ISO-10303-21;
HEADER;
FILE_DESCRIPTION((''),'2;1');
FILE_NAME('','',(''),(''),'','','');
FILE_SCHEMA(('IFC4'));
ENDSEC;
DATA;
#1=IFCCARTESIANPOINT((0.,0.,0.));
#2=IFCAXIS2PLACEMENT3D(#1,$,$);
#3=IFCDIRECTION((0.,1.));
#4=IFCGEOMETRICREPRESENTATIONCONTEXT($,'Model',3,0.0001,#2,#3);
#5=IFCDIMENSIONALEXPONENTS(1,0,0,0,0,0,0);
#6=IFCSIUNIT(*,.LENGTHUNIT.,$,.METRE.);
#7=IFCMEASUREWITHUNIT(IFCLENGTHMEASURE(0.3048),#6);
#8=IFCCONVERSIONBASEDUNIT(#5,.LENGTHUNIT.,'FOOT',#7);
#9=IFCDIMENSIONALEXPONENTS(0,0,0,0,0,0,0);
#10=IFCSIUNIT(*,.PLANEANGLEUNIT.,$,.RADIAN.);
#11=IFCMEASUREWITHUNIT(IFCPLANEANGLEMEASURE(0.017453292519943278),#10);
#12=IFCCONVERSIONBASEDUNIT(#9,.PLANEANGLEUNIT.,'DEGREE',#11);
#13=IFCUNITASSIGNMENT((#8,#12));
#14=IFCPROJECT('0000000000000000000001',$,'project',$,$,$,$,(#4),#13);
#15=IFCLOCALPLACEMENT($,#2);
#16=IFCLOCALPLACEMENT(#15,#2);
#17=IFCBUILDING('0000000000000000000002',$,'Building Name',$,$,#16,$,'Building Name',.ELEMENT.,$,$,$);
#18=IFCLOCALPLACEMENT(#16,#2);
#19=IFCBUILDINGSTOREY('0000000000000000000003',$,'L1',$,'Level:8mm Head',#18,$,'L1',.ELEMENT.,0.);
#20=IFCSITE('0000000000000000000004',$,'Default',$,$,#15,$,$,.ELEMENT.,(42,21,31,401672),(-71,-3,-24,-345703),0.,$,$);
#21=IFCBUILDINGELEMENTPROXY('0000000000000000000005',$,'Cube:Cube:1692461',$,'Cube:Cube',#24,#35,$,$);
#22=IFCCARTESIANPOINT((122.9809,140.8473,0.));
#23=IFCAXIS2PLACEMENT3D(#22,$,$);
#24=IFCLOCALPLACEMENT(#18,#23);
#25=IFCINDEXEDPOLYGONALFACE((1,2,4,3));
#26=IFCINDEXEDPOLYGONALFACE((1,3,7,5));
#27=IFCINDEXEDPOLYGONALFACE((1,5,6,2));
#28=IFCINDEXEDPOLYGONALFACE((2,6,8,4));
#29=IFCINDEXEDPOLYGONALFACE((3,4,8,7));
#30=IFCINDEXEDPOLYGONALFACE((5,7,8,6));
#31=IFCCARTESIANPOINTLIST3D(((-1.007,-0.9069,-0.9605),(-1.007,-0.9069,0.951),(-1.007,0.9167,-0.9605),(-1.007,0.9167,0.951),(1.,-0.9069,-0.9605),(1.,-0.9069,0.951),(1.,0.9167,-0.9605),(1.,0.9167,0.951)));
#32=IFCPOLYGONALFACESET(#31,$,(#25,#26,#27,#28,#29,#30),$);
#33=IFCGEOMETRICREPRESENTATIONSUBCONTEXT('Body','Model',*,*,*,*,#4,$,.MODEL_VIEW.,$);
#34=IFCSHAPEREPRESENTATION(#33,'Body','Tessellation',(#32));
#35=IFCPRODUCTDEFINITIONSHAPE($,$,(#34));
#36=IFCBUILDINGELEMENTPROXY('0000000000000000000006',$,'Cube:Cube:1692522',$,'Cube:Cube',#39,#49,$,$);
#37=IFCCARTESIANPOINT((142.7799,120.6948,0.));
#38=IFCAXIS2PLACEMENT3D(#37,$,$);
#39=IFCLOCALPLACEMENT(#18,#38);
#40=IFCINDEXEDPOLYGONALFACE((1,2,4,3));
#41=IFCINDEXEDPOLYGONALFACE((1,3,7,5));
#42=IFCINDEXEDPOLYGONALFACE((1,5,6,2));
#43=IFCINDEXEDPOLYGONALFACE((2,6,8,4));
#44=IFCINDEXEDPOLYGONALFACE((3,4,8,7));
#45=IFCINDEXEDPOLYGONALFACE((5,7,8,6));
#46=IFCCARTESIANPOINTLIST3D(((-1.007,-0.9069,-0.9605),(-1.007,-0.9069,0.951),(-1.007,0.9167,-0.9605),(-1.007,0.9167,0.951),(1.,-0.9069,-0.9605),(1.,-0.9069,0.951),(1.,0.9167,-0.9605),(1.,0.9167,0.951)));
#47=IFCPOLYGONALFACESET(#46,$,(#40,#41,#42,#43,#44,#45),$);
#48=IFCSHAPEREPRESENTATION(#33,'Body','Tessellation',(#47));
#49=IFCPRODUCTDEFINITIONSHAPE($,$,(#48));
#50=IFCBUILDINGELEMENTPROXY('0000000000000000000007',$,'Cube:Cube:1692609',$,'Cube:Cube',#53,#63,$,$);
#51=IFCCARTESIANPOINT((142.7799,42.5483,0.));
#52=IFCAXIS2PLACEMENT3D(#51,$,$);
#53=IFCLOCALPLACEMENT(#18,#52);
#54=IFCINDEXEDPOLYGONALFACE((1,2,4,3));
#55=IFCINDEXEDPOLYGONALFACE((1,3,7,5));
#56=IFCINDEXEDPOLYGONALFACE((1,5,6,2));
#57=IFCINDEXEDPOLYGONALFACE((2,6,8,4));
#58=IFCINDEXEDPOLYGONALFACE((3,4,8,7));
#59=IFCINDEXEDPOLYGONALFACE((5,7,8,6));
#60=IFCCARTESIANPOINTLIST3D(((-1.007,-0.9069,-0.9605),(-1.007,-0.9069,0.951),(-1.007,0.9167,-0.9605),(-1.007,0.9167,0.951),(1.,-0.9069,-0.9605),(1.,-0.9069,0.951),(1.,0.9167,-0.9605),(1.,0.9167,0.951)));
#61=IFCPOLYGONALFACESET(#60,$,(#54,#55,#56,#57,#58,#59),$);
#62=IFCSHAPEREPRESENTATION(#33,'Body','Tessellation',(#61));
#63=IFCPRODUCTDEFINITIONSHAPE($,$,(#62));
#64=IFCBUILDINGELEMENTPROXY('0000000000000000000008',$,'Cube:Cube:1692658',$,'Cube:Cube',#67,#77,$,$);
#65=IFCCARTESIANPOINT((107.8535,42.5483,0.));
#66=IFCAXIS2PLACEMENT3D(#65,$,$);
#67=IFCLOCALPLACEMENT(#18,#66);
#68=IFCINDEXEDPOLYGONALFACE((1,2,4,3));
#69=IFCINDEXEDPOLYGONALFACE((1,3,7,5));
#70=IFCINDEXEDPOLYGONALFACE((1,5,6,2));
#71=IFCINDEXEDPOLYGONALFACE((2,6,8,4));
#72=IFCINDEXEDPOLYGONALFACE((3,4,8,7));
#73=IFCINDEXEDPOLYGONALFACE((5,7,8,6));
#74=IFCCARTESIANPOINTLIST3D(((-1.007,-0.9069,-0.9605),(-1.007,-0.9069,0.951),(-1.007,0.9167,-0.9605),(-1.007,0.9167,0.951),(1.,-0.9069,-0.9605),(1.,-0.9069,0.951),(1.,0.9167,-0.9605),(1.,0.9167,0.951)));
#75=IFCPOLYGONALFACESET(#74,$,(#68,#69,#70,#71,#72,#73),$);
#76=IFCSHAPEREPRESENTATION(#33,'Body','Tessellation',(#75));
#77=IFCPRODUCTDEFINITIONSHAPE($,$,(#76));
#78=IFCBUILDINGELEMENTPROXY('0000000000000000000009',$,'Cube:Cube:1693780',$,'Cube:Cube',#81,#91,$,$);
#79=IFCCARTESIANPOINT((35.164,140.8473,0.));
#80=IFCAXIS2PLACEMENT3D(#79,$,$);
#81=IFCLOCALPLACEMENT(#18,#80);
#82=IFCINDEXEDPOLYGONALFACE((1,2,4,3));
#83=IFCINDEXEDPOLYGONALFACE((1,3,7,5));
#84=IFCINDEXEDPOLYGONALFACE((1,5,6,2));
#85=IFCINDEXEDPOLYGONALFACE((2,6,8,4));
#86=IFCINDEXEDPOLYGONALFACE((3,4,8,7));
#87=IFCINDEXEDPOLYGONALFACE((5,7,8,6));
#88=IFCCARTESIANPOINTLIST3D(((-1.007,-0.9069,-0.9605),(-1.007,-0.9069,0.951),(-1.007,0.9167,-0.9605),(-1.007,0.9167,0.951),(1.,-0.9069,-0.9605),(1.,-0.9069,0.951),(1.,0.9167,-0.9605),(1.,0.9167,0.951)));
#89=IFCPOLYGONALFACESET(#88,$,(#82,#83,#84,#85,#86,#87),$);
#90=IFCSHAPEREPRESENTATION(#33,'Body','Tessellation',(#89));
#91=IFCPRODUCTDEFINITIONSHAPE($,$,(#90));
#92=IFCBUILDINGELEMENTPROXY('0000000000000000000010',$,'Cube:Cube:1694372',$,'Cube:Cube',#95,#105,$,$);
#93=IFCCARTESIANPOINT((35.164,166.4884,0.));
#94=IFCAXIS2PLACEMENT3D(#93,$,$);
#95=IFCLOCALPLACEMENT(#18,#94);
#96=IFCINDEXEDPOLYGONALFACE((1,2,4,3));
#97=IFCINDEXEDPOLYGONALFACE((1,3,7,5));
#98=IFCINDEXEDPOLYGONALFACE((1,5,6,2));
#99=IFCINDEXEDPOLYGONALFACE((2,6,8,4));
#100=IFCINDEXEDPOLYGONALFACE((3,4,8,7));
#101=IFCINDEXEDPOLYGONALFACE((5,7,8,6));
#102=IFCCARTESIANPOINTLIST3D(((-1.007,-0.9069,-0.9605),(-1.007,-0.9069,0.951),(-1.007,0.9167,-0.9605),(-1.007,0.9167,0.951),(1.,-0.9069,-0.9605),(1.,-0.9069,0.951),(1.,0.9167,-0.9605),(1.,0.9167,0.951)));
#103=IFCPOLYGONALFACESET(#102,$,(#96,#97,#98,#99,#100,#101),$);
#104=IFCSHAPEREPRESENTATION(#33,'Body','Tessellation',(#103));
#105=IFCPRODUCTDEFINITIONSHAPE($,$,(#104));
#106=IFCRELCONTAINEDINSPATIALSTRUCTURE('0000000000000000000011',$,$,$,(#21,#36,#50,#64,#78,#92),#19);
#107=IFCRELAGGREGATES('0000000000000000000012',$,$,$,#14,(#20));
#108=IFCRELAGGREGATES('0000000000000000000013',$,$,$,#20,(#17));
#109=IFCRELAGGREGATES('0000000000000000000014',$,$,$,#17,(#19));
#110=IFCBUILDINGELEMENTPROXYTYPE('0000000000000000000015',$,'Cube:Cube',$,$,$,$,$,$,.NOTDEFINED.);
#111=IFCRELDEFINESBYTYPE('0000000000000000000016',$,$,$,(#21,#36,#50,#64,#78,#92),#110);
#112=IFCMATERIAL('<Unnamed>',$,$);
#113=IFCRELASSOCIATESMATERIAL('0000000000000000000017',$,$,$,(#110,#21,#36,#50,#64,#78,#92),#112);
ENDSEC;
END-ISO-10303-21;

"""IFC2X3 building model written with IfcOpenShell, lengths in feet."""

from ifc_helpers import new_model, entity, si_unit, converted_unit, direction, frame, frame_2d, origin, place, context, subcontext, project, spatial, rectangle, extrude, source, transform, mapped, material, type_object, type_shapes, element, save


model = new_model("IFC2X3")

# Units and contexts
model_context = context("Model", 3, precision=0.0001, world=origin(), true_north=direction((0.0, 1.0)))
body_context = subcontext(model_context, "Body", "Model", "MODEL_VIEW")
ifc_project = project(units=[converted_unit("LENGTHUNIT", "FOOT", entity("IfcLengthMeasure", 0.3048), si_unit("LENGTHUNIT", "METRE"), dimensions=[1, 0, 0, 0, 0, 0, 0]), converted_unit("PLANEANGLEUNIT", "DEGREE", entity("IfcPlaneAngleMeasure", 0.017453292519943278), si_unit("PLANEANGLEUNIT", "RADIAN"), dimensions=[0, 0, 0, 0, 0, 0, 0])], contexts=[model_context])

# Site, building, storey
site_placement = place(None, origin())
site = spatial("IfcSite", under=ifc_project, at=site_placement, Name="Default", CompositionType="ELEMENT", RefLatitude=(42, 21, 31, 401672), RefLongitude=(-71, -3, -24, -345703), RefElevation=0.0)
building_placement = place(site_placement, origin())
building = spatial("IfcBuilding", under=site, at=building_placement, Name="Building Name", LongName="Building Name", CompositionType="ELEMENT")
storey_placement = place(building_placement, origin())
storey = spatial("IfcBuildingStorey", under=building, at=storey_placement, Name="L1", ObjectType="Level:8mm Head", LongName="L1", CompositionType="ELEMENT", Elevation=0.0)

# Building element proxies
ifc_material_1 = material(Name="<Unnamed>")
building_element_proxy_type = type_object("IfcBuildingElementProxyType", Name="Cube:Cube", PredefinedType="NOTDEFINED", material=ifc_material_1)
shared_shape = source(origin(), body_context, "Body", "SweptSolid", [
    extrude(rectangle(XDim=1.8235, YDim=2.007, at=frame_2d((0.0, 0.0), x_axis=(1.0, 0.0))), frame((-0.0035, 0.0049, -0.9605), z_axis=(0.0, 0.0, 1.0), x_axis=(0.0, 1.0, 0.0)), (0.0, 0.0, 1.0), 1.9115),
])
type_shapes(building_element_proxy_type, [shared_shape])
for number, where, name in (
    (1, (122.9809, 140.8473, 0.0), "Cube:Cube:1692461"),
    (2, (142.7799, 120.6948, 0.0), "Cube:Cube:1692522"),
    (3, (142.7799, 42.5483, 0.0), "Cube:Cube:1692609"),
    (4, (107.8535, 42.5483, 0.0), "Cube:Cube:1692658"),
    (5, (35.164, 140.8473, 0.0), "Cube:Cube:1693780"),
    (6, (35.164, 166.4884, 0.0), "Cube:Cube:1694372"),
):
    element("IfcBuildingElementProxy", number, at=place(storey_placement, frame(where)), inside=storey, type_object=building_element_proxy_type, material=ifc_material_1, Name=name, ObjectType="Cube:Cube", context=body_context, shape_type="MappedRepresentation", body=[
        mapped(shared_shape, transform((0.0, 0.0, 0.0), scale=1.0)),
    ])

save(model, "model.ifc")
